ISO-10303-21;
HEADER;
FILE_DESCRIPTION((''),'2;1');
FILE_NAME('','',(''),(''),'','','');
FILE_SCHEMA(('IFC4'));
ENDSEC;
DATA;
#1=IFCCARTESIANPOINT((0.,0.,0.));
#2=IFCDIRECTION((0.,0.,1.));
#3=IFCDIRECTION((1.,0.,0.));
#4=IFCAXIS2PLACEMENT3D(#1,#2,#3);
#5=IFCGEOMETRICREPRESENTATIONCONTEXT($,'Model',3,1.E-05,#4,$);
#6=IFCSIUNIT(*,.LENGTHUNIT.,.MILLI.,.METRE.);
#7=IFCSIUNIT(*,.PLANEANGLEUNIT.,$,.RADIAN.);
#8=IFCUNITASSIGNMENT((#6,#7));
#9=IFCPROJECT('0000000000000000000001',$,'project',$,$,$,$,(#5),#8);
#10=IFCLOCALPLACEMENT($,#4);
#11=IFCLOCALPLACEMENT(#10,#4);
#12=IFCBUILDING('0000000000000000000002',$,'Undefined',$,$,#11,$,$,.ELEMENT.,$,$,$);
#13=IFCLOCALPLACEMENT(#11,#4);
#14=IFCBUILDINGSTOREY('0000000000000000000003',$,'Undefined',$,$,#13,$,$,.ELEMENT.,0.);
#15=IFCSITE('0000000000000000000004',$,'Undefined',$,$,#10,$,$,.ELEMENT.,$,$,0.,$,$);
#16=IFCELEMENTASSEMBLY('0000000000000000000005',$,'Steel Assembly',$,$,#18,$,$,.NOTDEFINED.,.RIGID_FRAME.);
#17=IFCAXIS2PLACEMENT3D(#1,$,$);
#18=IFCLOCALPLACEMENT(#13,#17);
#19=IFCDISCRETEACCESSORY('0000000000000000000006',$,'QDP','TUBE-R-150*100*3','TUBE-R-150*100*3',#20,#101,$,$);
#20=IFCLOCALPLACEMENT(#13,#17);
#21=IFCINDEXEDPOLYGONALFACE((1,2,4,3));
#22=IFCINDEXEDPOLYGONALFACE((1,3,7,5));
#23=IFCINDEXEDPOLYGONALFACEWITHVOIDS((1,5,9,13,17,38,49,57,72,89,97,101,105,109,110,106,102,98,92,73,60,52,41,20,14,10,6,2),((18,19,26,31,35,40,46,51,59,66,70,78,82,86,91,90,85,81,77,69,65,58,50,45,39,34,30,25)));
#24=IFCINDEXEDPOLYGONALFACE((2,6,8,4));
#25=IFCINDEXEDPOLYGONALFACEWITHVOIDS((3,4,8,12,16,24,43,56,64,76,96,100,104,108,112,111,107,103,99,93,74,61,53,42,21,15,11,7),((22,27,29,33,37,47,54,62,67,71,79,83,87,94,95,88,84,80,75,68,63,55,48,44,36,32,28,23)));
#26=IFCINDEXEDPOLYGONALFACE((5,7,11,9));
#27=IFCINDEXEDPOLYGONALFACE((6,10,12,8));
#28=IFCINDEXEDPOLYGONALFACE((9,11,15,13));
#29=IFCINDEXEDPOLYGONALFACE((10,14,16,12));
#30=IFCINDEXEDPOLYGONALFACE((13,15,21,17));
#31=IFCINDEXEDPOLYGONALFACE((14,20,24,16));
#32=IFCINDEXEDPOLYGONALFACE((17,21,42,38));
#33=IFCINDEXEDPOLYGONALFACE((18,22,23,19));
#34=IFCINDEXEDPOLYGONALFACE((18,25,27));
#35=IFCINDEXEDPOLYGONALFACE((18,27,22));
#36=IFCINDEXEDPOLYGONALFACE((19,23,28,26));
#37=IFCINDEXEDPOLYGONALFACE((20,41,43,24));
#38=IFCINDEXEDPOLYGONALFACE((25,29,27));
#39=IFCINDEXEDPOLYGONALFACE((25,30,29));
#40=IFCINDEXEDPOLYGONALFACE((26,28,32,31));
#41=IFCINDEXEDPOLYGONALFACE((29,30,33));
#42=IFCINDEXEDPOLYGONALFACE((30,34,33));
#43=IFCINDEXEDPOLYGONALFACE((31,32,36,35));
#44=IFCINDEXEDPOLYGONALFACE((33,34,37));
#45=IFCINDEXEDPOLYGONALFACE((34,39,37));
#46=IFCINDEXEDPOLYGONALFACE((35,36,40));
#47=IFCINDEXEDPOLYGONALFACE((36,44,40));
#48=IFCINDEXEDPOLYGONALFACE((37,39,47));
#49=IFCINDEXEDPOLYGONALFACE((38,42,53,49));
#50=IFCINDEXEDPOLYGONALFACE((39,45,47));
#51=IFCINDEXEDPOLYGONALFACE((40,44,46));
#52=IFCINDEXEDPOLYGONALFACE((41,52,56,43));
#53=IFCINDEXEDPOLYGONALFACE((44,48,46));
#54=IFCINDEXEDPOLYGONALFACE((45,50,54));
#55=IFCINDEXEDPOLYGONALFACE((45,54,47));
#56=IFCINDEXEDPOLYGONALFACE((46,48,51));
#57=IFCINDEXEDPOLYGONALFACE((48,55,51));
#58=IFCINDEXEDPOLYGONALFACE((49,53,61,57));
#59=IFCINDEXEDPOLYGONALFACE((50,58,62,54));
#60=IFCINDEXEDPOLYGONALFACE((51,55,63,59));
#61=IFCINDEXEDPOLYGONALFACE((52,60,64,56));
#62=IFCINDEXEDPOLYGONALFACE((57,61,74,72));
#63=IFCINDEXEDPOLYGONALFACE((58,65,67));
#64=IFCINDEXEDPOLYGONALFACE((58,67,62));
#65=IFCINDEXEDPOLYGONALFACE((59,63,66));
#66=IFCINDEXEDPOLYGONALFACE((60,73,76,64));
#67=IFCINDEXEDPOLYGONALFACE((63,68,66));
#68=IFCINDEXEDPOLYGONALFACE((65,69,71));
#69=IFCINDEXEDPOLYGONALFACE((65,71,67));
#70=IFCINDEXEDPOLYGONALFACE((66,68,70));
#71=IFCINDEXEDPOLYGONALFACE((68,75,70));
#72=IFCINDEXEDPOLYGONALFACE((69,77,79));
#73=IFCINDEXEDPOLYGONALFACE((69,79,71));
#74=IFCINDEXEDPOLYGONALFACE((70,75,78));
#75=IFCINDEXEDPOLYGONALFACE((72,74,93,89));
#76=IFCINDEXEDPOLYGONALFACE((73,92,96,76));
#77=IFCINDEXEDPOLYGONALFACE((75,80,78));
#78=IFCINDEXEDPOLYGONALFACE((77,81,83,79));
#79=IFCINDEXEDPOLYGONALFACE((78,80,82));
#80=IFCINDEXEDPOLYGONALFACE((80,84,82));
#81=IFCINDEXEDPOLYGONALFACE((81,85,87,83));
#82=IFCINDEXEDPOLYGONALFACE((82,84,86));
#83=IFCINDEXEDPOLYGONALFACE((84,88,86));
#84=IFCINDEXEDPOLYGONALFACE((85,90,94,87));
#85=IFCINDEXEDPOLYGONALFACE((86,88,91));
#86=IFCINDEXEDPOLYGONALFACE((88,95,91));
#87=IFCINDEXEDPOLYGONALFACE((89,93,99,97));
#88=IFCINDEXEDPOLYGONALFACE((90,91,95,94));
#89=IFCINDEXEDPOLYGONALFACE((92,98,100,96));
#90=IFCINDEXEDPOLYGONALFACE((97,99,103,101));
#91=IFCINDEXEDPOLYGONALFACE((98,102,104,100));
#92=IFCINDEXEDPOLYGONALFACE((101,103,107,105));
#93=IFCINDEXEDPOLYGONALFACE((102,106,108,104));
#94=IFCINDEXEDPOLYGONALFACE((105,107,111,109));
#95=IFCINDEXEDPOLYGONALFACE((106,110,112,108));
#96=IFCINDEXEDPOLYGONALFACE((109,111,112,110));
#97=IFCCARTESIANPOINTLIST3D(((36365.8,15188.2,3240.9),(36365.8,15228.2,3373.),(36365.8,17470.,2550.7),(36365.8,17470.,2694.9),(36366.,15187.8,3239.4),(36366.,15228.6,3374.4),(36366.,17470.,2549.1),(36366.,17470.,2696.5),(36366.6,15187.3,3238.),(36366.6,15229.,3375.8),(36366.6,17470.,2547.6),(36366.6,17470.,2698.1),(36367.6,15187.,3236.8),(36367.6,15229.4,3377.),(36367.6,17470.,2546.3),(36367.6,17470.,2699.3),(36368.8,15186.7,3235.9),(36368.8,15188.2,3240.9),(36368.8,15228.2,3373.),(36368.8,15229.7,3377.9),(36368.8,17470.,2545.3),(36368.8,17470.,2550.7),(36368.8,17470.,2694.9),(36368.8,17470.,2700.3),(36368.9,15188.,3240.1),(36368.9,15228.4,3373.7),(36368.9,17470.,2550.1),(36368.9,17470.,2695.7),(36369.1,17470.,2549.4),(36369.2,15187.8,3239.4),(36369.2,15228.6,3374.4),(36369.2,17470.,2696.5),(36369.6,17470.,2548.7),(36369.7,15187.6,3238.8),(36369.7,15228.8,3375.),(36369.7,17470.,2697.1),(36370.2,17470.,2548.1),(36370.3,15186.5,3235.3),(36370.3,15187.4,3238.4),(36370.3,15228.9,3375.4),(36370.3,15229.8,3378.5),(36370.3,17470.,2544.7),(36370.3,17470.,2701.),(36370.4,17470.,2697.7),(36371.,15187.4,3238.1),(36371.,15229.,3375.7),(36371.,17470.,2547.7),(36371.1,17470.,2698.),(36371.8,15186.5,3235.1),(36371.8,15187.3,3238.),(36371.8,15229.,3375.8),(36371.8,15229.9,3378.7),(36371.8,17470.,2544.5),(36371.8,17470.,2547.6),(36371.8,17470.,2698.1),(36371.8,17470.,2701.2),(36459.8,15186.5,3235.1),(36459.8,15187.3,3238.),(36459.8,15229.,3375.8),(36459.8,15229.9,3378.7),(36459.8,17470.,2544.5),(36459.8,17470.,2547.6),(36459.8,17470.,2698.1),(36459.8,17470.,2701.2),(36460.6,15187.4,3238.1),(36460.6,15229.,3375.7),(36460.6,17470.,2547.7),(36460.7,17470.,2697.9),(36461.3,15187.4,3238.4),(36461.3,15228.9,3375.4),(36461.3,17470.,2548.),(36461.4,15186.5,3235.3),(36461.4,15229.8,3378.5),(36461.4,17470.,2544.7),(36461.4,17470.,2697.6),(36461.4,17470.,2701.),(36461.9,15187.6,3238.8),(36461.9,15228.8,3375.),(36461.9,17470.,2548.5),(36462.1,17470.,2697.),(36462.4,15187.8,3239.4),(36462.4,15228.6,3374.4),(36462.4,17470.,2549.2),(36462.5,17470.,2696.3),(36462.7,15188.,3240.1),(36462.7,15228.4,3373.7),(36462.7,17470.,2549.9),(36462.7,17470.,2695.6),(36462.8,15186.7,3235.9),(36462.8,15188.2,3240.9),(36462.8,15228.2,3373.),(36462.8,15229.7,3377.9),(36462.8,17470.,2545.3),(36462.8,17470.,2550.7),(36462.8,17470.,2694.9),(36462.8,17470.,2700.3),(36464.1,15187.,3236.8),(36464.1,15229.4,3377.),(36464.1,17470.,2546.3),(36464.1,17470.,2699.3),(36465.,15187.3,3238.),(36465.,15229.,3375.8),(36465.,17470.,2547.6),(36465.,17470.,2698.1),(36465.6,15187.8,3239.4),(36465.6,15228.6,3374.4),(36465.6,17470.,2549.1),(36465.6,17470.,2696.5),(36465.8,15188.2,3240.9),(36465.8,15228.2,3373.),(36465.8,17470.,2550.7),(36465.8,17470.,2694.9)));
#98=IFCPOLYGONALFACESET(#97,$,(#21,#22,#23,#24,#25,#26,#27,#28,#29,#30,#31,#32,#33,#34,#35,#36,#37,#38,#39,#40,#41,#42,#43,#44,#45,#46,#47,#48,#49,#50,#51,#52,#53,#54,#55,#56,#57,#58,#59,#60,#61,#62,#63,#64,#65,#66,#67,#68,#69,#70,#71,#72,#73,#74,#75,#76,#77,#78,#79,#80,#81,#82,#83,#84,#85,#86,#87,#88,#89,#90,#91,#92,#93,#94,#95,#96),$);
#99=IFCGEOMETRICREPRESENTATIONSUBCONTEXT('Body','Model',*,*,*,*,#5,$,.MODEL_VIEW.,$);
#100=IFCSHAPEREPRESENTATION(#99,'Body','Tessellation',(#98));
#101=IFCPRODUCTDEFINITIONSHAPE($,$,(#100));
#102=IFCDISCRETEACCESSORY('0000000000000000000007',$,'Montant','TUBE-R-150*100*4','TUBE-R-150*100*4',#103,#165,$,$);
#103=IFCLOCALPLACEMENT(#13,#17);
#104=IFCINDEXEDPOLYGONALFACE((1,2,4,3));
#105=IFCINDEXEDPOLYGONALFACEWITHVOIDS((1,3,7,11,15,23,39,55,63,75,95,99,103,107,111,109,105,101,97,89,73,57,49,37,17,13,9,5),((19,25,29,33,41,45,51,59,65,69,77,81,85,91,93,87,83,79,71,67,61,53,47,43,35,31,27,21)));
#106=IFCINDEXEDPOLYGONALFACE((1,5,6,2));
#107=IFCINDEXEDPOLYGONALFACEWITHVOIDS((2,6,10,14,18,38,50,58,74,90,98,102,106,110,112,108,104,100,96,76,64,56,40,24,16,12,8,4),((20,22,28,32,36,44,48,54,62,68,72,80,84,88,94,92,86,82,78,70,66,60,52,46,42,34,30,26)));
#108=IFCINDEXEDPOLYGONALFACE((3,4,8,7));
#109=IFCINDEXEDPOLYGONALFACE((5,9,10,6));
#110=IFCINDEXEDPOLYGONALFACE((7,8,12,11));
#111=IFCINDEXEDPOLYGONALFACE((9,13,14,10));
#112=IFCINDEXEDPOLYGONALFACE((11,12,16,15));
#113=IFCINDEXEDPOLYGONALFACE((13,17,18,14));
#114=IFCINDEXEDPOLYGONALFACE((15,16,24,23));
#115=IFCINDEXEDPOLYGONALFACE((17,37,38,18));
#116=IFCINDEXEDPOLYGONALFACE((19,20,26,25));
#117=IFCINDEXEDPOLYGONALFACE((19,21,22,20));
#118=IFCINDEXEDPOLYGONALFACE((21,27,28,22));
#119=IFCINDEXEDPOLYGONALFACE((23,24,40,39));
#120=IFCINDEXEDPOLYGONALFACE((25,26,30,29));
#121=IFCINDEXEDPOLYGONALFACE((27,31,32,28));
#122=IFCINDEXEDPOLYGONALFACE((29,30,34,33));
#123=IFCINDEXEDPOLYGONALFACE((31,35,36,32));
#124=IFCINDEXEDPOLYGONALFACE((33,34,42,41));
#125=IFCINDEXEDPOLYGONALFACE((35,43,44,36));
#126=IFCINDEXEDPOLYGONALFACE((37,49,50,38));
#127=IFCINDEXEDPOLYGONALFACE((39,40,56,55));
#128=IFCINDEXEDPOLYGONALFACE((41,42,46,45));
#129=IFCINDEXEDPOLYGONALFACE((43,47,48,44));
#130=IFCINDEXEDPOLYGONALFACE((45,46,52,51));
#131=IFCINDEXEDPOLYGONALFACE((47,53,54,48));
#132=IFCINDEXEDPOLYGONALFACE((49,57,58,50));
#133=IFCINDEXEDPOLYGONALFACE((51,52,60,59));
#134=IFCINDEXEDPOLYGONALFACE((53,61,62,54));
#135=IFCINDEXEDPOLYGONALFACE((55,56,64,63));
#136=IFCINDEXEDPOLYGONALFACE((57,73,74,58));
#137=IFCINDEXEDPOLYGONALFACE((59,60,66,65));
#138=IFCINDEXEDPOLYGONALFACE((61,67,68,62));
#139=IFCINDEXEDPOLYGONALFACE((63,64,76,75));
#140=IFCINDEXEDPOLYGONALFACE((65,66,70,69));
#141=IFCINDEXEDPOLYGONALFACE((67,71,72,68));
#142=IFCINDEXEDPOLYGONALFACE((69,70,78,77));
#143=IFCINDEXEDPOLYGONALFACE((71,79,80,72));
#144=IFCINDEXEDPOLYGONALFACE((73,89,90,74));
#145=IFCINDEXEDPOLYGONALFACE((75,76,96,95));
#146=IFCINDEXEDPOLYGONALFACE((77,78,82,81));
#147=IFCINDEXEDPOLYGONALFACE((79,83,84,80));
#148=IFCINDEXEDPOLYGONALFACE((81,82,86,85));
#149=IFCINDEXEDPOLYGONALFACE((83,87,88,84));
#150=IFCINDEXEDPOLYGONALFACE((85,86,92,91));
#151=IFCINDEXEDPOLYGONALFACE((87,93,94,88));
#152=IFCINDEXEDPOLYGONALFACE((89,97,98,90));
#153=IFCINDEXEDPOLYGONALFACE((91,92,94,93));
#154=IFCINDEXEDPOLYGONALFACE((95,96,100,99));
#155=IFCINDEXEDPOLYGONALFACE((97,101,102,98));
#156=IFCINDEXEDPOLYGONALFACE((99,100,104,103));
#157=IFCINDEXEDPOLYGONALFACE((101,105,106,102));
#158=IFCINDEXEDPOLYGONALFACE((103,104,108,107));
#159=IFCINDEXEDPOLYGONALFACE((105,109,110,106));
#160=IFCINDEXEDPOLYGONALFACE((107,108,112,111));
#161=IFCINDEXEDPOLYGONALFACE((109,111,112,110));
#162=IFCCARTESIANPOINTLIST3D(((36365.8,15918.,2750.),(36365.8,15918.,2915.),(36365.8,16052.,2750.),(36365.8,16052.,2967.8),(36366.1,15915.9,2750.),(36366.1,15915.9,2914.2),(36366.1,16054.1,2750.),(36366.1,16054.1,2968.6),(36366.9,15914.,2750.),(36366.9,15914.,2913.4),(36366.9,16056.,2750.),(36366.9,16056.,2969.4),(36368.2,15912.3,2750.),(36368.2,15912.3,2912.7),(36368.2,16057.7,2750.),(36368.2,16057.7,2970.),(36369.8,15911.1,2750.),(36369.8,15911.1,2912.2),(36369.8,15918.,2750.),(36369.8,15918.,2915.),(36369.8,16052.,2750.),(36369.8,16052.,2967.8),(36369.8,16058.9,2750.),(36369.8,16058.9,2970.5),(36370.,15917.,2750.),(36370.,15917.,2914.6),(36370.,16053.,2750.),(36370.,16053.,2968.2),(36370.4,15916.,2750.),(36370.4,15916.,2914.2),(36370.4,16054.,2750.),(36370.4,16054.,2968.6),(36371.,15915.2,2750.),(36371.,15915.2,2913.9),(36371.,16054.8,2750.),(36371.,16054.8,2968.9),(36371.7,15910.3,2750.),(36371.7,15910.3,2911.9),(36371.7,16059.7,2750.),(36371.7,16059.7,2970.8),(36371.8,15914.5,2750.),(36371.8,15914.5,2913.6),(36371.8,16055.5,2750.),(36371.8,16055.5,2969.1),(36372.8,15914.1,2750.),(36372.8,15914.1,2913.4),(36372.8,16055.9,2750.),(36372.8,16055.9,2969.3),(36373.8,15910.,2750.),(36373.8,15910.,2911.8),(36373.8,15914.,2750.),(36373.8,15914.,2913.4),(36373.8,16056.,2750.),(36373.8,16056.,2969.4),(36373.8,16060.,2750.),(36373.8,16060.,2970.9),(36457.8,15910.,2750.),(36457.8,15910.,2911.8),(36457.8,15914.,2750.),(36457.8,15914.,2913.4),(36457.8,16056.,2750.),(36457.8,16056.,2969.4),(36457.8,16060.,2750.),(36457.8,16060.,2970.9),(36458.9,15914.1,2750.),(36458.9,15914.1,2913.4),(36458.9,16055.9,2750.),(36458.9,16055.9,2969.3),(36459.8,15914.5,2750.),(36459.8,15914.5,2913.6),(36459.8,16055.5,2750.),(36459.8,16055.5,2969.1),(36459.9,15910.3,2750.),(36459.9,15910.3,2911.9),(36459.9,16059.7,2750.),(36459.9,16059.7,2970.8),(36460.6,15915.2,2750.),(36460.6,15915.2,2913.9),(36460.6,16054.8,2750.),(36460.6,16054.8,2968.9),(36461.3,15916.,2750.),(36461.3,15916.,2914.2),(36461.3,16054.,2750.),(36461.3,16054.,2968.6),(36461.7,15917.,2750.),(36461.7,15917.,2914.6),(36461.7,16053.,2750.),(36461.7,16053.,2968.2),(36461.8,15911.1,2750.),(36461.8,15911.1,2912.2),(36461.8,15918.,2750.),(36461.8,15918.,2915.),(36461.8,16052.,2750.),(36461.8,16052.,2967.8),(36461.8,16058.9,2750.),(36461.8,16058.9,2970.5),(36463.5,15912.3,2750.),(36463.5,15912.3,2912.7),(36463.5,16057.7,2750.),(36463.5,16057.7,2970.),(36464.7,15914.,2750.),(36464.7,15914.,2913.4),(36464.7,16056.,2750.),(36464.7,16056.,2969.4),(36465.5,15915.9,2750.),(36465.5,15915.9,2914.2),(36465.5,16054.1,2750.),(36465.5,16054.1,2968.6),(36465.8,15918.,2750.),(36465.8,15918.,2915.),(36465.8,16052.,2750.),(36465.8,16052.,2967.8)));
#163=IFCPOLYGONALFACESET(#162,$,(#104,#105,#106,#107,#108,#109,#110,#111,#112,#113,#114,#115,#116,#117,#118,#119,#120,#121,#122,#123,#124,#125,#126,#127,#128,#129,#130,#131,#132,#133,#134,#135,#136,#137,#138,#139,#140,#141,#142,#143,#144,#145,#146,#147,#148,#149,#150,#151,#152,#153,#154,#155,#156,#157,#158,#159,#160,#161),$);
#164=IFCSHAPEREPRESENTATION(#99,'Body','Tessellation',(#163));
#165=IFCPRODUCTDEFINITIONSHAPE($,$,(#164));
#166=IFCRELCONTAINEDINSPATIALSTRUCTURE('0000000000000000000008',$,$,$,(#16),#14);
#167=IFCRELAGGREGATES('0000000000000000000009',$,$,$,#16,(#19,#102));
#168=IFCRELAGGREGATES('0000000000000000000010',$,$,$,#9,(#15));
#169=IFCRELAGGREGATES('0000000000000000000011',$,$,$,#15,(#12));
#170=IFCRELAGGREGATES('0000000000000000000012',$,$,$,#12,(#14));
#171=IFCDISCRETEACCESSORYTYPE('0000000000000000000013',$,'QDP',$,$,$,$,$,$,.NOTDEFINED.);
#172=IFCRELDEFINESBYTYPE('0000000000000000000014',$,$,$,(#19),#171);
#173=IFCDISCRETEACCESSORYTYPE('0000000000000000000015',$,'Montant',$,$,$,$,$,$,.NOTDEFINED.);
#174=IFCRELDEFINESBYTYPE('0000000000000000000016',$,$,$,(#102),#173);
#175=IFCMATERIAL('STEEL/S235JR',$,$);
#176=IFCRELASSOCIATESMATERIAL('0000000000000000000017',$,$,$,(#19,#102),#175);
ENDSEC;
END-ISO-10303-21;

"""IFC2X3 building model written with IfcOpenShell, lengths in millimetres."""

from ifc_helpers import new_model, si_unit, frame, origin_with_axes, origin_2d_with_axis, place, context, subcontext, project, spatial, hollow_rectangle, extrude, clip, halfspace, material, type_object, element, aggregate, save


model = new_model("IFC2X3")

# Units and contexts
model_context = context("Model", 3, precision=1e-05, world=origin_with_axes())
body_context = subcontext(model_context, "Body", "Model", "MODEL_VIEW")
ifc_project = project(units=[si_unit("LENGTHUNIT", "METRE", prefix="MILLI"), si_unit("PLANEANGLEUNIT", "RADIAN")], contexts=[model_context])

# Site, building, storey
site_placement = place(None, origin_with_axes())
site = spatial("IfcSite", under=ifc_project, at=site_placement, Name="Undefined", CompositionType="ELEMENT", RefElevation=0.0)
building_placement = place(site_placement, origin_with_axes())
building = spatial("IfcBuilding", under=site, at=building_placement, Name="Undefined", CompositionType="ELEMENT")
storey_placement = place(building_placement, origin_with_axes())
storey = spatial("IfcBuildingStorey", under=building, at=storey_placement, Name="Undefined", CompositionType="ELEMENT", Elevation=0.0)

# Shared definitions
ifc_material_1 = material(Name="STEEL/S235JR")

# Element assembly
assembly_1_placement = place(storey_placement, origin_with_axes())
assembly_1 = element("IfcElementAssembly", 1, at=assembly_1_placement, inside=storey, Name="Steel Assembly", AssemblyPlace="NOTDEFINED", PredefinedType="RIGID_FRAME")

# Discrete accessories
discrete_accessory_type_1 = type_object("IfcDiscreteAccessoryType", Name="QDP")
discrete_accessory_1_placement = place(assembly_1_placement, frame((36415.8, 15208.1, 3306.9), z_axis=(0.0, 0.289497, 0.957179), x_axis=(0.0, 0.957179, -0.289497)))
discrete_accessory_1 = element("IfcDiscreteAccessory", 2, at=discrete_accessory_1_placement, type_object=discrete_accessory_type_1, material=ifc_material_1, Name="QDP", Description="TUBE-R-150*100*3", ObjectType="TUBE-R-150*100*3", context=body_context, shape_type="Clipping", body=[
    clip(extrude(hollow_rectangle(XDim=100.0, YDim=150.0, WallThickness=3.0, InnerFilletRadius=3.0, OuterFilletRadius=6.0, at=origin_2d_with_axis()), frame((2427.9, 0.0, 0.0), z_axis=(-1.0, 0.0, 0.0), x_axis=(0.0, -1.0, 0.0)), (0.0, 0.0, 1.0), 2427.9), halfspace(frame((2361.5, 0.0, 5.2), z_axis=(0.957179, 0.0, 0.289497), x_axis=(0.0, -1.0, 0.0)), False)),
])
discrete_accessory_type_2 = type_object("IfcDiscreteAccessoryType", Name="Montant")
discrete_accessory_2_placement = place(assembly_1_placement, frame((36415.8, 15985.0, 3075.7), z_axis=(0.0, 1.0, 0.0), x_axis=(0.0, 0.0, -1.0)))
discrete_accessory_2 = element("IfcDiscreteAccessory", 3, at=discrete_accessory_2_placement, type_object=discrete_accessory_type_2, material=ifc_material_1, Name="Montant", Description="TUBE-R-150*100*4", ObjectType="TUBE-R-150*100*4", context=body_context, shape_type="Clipping", body=[
    clip(extrude(hollow_rectangle(XDim=100.0, YDim=150.0, WallThickness=4.0, InnerFilletRadius=4.0, OuterFilletRadius=8.0, at=origin_2d_with_axis()), frame((325.7, 0.0, 0.0), z_axis=(-1.0, 0.0, 0.0), x_axis=(0.0, -1.0, 0.0)), (0.0, 0.0, 1.0), 221.2), halfspace(frame((163.9, -50.0, -75.0), z_axis=(0.930375, 0.0, 0.366608), x_axis=(0.0, -1.0, 0.0)), True)),
])
aggregate(assembly_1, [discrete_accessory_1, discrete_accessory_2])

save(model, "model.ifc")
